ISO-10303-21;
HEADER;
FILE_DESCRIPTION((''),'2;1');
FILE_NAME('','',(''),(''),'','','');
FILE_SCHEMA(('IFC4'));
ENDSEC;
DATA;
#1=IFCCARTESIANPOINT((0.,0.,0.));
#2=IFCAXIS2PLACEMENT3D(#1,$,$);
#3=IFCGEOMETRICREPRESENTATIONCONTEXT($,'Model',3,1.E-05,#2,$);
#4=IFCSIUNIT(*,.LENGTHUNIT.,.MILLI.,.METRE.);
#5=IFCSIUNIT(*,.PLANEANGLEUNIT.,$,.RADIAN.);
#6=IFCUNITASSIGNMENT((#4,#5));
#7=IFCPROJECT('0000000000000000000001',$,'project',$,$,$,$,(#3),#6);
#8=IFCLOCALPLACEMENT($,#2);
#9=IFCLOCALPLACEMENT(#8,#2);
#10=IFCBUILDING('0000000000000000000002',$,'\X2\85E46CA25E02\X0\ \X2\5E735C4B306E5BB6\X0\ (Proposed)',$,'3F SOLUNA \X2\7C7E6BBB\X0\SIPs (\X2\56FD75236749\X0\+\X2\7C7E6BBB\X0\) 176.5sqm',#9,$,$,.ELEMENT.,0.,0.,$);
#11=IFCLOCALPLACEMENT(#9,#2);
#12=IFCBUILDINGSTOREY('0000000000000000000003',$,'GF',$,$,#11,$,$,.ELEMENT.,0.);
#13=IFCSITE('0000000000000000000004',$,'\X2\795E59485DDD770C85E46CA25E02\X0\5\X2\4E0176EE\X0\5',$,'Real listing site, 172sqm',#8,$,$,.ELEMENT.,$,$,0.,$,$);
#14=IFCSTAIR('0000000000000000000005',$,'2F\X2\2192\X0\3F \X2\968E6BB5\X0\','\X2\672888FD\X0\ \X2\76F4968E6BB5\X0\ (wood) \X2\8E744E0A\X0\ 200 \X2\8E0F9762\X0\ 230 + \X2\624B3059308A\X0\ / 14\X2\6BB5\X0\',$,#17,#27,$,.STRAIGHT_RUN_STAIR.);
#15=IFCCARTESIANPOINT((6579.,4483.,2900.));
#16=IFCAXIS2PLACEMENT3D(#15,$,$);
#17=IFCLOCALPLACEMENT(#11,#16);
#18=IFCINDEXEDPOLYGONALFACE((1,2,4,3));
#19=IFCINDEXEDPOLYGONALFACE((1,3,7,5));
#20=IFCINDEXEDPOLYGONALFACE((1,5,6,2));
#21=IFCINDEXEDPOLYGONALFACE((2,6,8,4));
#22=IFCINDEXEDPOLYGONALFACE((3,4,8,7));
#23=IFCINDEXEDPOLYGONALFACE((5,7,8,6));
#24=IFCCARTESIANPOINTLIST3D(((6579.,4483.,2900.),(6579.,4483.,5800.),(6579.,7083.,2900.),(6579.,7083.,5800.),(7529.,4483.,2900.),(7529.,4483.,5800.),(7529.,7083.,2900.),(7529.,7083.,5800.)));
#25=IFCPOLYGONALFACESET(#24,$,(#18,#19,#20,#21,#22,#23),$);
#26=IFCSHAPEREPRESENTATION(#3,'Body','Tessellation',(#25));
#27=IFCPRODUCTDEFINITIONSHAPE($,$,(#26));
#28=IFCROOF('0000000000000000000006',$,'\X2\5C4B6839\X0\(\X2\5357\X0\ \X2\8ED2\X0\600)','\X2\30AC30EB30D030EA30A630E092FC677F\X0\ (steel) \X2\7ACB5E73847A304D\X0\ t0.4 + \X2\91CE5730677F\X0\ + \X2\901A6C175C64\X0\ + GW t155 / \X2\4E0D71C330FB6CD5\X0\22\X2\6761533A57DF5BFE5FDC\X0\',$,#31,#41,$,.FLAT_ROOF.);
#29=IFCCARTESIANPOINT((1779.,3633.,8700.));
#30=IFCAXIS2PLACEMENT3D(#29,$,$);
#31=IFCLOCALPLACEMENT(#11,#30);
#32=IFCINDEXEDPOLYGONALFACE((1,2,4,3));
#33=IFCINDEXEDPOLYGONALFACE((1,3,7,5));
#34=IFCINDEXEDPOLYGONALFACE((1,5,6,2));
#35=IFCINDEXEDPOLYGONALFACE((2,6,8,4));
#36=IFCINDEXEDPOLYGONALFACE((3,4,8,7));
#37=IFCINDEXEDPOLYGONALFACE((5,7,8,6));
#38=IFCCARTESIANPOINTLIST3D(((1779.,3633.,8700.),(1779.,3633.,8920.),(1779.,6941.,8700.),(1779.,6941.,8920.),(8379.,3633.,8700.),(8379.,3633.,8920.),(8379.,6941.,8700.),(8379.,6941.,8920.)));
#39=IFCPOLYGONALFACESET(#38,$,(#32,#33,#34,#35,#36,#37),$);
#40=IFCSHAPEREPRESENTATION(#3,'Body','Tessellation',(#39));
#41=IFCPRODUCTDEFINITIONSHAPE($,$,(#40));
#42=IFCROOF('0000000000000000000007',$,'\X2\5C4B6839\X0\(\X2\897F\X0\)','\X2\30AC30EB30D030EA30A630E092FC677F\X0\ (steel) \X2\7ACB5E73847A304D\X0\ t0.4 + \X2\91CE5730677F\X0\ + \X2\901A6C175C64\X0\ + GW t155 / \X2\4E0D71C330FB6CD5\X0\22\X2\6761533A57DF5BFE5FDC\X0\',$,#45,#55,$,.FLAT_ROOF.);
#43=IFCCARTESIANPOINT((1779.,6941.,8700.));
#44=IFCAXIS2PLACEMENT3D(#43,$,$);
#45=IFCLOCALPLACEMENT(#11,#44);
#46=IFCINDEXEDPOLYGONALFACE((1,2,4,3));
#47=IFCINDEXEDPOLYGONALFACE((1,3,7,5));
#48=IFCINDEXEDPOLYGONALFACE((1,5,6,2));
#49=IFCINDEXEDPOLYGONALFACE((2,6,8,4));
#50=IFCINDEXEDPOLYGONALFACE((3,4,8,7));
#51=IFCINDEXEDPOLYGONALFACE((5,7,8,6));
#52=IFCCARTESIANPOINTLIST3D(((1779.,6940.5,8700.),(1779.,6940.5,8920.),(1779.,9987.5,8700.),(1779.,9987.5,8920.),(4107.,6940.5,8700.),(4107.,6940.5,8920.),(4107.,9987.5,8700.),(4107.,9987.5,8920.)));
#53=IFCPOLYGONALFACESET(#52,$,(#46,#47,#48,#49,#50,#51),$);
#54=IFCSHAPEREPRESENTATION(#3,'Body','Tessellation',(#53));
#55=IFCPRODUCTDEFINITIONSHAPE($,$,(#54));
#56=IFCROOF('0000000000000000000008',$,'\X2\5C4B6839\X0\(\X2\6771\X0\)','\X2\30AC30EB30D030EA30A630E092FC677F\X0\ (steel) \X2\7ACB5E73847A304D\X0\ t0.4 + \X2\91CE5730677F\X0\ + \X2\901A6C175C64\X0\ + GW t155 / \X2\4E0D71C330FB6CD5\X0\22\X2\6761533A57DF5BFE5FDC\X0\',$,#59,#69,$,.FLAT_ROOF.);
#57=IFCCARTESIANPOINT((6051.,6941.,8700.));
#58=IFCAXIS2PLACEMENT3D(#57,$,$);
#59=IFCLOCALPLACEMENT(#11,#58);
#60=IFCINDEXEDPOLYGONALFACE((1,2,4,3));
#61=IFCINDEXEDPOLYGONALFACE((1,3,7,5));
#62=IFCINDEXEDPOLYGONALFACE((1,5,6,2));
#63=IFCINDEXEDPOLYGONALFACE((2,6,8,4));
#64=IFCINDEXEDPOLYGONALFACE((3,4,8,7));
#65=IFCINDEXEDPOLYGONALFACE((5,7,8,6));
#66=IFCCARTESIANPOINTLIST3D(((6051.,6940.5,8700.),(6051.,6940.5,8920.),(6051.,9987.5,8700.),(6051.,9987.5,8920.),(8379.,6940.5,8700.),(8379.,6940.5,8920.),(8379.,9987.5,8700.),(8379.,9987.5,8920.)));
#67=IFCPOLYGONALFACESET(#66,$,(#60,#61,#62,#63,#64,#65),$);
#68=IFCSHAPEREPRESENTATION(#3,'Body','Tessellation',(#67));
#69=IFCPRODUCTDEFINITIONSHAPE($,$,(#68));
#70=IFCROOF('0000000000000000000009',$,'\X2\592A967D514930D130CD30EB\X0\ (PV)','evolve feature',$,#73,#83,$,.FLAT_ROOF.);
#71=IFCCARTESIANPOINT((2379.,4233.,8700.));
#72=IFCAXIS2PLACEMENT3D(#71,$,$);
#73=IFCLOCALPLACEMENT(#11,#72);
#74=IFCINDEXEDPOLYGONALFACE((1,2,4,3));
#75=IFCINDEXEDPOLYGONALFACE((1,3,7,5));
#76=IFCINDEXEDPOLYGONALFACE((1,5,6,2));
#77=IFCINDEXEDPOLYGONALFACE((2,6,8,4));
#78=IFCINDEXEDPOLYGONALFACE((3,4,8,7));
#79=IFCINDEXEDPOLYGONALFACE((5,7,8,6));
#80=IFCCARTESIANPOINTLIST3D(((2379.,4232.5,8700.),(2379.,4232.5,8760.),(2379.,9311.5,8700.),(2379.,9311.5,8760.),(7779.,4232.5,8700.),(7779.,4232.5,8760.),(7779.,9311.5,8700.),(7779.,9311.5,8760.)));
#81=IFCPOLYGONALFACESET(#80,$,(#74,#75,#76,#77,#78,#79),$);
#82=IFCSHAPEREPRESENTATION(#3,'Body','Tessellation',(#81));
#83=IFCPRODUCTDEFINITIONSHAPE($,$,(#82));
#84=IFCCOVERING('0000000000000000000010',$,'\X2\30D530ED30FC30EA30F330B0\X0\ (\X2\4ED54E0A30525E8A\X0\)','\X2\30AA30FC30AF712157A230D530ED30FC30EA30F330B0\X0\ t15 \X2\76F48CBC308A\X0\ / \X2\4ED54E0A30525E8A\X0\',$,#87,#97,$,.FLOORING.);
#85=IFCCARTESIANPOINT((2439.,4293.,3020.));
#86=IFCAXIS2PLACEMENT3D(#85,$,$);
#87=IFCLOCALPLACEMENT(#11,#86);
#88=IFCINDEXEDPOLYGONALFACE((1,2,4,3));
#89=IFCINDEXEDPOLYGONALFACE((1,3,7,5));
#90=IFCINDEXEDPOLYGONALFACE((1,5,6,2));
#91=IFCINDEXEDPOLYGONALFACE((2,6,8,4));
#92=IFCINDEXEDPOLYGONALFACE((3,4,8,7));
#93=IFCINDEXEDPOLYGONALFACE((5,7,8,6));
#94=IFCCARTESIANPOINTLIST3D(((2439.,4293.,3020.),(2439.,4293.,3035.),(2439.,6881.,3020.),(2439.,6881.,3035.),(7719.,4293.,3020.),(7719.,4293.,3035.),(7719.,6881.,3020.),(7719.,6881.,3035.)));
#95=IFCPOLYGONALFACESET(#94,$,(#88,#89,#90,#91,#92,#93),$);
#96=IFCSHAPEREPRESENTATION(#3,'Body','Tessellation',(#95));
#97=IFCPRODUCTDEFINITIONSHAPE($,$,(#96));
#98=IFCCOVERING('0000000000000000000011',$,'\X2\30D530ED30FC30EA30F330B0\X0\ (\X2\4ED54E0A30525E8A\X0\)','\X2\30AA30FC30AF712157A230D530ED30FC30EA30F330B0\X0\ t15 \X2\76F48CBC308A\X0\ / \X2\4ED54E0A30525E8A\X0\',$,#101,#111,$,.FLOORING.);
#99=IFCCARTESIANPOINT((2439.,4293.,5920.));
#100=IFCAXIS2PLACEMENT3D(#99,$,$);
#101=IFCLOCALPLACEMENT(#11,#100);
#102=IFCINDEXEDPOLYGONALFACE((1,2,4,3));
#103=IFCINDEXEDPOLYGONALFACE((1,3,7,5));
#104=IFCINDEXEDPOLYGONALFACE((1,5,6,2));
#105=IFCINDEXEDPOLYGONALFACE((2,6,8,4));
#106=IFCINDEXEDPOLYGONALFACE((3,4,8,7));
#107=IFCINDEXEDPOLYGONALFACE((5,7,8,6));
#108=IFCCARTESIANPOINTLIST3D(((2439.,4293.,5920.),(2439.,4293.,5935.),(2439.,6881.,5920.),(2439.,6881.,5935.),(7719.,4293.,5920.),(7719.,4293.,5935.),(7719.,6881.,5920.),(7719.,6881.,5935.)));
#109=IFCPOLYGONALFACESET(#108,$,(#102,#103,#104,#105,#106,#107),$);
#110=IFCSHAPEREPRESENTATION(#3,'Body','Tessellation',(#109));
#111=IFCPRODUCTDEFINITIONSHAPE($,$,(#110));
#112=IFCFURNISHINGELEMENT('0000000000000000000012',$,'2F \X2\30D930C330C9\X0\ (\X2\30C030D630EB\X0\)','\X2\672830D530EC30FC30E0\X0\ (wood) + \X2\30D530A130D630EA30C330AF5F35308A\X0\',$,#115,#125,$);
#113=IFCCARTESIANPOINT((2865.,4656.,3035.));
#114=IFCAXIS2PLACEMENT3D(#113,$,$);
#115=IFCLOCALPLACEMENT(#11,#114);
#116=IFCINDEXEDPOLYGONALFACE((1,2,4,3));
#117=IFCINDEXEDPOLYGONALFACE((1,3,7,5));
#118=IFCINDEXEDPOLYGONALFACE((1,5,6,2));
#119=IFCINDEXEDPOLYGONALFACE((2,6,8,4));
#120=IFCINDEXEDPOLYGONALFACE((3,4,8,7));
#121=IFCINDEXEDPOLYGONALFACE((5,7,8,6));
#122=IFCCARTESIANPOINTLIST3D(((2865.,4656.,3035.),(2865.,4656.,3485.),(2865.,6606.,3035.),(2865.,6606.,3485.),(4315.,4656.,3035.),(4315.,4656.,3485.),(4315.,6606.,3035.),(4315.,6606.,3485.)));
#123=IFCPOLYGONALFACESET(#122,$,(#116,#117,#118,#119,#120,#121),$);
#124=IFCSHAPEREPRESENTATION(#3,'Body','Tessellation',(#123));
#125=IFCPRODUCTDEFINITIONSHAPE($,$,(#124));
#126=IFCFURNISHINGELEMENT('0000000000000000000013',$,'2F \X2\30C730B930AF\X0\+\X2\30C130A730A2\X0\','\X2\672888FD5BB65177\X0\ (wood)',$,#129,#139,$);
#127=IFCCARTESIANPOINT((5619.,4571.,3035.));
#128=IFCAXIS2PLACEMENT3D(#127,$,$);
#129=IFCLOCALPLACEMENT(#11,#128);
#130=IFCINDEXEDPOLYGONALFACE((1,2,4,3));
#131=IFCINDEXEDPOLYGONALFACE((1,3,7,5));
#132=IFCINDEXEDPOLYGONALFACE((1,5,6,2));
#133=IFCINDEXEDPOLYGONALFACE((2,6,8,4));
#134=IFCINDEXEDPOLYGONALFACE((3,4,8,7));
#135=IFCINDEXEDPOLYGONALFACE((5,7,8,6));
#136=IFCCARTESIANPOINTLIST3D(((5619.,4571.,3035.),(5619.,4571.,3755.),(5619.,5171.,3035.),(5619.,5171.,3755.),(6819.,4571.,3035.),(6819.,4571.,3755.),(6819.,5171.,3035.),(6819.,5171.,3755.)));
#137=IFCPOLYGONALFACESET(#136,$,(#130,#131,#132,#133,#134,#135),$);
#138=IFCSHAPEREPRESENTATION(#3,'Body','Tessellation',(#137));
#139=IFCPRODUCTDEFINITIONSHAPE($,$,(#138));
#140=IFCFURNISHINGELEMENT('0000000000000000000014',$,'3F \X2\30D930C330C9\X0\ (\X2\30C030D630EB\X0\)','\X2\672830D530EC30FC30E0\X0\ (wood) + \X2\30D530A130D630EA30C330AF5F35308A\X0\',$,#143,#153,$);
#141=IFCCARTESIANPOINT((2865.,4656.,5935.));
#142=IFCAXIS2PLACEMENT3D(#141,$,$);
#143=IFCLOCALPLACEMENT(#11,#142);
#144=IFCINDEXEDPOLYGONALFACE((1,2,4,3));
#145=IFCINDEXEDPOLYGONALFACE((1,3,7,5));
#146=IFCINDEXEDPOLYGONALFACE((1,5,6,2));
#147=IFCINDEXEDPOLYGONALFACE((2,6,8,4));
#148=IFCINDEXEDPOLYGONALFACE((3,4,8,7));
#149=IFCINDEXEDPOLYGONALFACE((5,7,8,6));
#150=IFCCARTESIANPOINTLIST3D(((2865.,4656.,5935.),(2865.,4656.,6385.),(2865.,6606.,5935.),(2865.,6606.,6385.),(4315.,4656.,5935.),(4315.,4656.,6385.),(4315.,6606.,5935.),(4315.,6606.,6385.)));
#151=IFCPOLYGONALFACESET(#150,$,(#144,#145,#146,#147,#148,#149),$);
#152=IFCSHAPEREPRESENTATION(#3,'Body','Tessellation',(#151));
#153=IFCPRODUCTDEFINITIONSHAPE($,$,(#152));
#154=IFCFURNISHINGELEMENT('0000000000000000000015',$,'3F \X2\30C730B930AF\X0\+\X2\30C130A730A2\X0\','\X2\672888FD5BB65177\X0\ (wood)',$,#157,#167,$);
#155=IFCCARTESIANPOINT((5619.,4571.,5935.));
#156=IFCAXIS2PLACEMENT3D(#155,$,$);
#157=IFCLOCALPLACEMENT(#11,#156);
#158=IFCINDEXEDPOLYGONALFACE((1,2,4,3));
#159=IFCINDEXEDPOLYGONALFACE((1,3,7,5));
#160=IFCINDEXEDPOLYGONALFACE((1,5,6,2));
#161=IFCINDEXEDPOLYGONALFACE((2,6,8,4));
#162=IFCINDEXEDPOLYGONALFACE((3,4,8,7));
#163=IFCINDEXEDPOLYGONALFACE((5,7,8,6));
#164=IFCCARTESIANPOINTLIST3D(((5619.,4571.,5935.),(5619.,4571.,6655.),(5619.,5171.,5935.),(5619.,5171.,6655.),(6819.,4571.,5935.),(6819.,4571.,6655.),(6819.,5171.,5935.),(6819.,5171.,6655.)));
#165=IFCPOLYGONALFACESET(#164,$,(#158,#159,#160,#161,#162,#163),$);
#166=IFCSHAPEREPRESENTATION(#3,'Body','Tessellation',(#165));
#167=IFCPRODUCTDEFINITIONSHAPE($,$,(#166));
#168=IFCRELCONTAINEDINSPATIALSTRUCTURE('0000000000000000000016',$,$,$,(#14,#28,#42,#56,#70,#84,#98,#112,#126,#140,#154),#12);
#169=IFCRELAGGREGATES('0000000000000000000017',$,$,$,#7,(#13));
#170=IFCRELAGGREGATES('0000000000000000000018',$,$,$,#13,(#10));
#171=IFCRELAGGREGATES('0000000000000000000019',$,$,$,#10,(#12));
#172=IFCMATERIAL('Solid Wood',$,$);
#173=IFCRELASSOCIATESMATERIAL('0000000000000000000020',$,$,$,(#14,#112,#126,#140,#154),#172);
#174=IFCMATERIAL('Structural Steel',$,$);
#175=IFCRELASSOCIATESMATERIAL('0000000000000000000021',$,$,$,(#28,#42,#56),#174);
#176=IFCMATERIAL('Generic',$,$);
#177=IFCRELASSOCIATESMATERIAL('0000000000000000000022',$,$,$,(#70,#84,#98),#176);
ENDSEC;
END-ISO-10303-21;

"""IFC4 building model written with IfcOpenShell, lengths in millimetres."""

from ifc_helpers import new_model, si_unit, frame, frame_2d, origin, place, context, project, spatial, rectangle, extrude, material, element, save


model = new_model("IFC4")

# Units and contexts
model_context = context("Model", 3, precision=1e-05, world=origin())
ifc_project = project(units=[si_unit("LENGTHUNIT", "METRE", prefix="MILLI"), si_unit("PLANEANGLEUNIT", "RADIAN")], contexts=[model_context])

# Site, building, storey
site_placement = place(None, origin())
site = spatial("IfcSite", under=ifc_project, at=site_placement, Name="神奈川県藤沢市5丁目5", ObjectType="Real listing site, 172sqm", CompositionType="ELEMENT", RefElevation=0.0)
building_placement = place(site_placement, origin())
building = spatial("IfcBuilding", under=site, at=building_placement, Name="藤沢市 平屋の家 (Proposed)", ObjectType="3F SOLUNA 籾殻SIPs (国産杉+籾殻) 176.5sqm", CompositionType="ELEMENT", ElevationOfRefHeight=0.0, ElevationOfTerrain=0.0)
storey_placement = place(building_placement, origin())
storey = spatial("IfcBuildingStorey", under=building, at=storey_placement, Name="GF", CompositionType="ELEMENT", Elevation=0.0)

# Shared definitions
ifc_material_1 = material(Name="Solid Wood")

# Stair
stair_placement = place(storey_placement, frame((6579.0, 4483.0, 2900.0)))
element("IfcStair", 1, at=stair_placement, inside=storey, material=ifc_material_1, Name="2F→3F 階段", Description="木製 直階段 (wood) 蹴上 200 踏面 230 + 手すり / 14段", PredefinedType="STRAIGHT_RUN_STAIR", context=model_context, shape_type="SweptSolid", body=[
    extrude(rectangle(XDim=950.0, YDim=2600.0, at=frame_2d((475.0, 1300.0))), frame((6579.0, 4483.0, 2900.0)), (0.0, 0.0, 1.0), 2900.0),
])

# Roofs
ifc_material_2 = material(Name="Structural Steel")
roof_1_placement = place(storey_placement, frame((1779.0, 3633.0, 8700.0)))
element("IfcRoof", 2, at=roof_1_placement, inside=storey, material=ifc_material_2, Name="屋根(南 軒600)", Description="ガルバリウム鋼板 (steel) 立平葺き t0.4 + 野地板 + 通気層 + GW t155 / 不燃・法22条区域対応", PredefinedType="FLAT_ROOF", context=model_context, shape_type="SweptSolid", body=[
    extrude(rectangle(XDim=6600.0, YDim=3308.0, at=frame_2d((3300.0, 1654.0))), frame((1779.0, 3633.0, 8700.0)), (0.0, 0.0, 1.0), 220.0),
])
roof_2_placement = place(storey_placement, frame((1779.0, 6941.0, 8700.0)))
element("IfcRoof", 3, at=roof_2_placement, inside=storey, material=ifc_material_2, Name="屋根(西)", Description="ガルバリウム鋼板 (steel) 立平葺き t0.4 + 野地板 + 通気層 + GW t155 / 不燃・法22条区域対応", PredefinedType="FLAT_ROOF", context=model_context, shape_type="SweptSolid", body=[
    extrude(rectangle(XDim=2328.0, YDim=3047.0, at=frame_2d((1164.0, 1523.0))), frame((1779.0, 6941.0, 8700.0)), (0.0, 0.0, 1.0), 220.0),
])
roof_3_placement = place(storey_placement, frame((6051.0, 6941.0, 8700.0)))
element("IfcRoof", 4, at=roof_3_placement, inside=storey, material=ifc_material_2, Name="屋根(東)", Description="ガルバリウム鋼板 (steel) 立平葺き t0.4 + 野地板 + 通気層 + GW t155 / 不燃・法22条区域対応", PredefinedType="FLAT_ROOF", context=model_context, shape_type="SweptSolid", body=[
    extrude(rectangle(XDim=2328.0, YDim=3047.0, at=frame_2d((1164.0, 1523.0))), frame((6051.0, 6941.0, 8700.0)), (0.0, 0.0, 1.0), 220.0),
])
ifc_material_3 = material(Name="Generic")
roof_4_placement = place(storey_placement, frame((2379.0, 4233.0, 8700.0)))
element("IfcRoof", 5, at=roof_4_placement, inside=storey, material=ifc_material_3, Name="太陽光パネル (PV)", Description="evolve feature", PredefinedType="FLAT_ROOF", context=model_context, shape_type="SweptSolid", body=[
    extrude(rectangle(XDim=5400.0, YDim=5079.0, at=frame_2d((2700.0, 2539.0))), frame((2379.0, 4233.0, 8700.0)), (0.0, 0.0, 1.0), 60.0),
])

# Coverings
covering_1_placement = place(storey_placement, frame((2439.0, 4293.0, 3020.0)))
element("IfcCovering", 6, at=covering_1_placement, inside=storey, material=ifc_material_3, Name="フローリング (仕上げ床)", Description="オーク無垢フローリング t15 直貼り / 仕上げ床", PredefinedType="FLOORING", context=model_context, shape_type="SweptSolid", body=[
    extrude(rectangle(XDim=5280.0, YDim=2588.0, at=frame_2d((2640.0, 1294.0))), frame((2439.0, 4293.0, 3020.0)), (0.0, 0.0, 1.0), 15.0),
])
covering_2_placement = place(storey_placement, frame((2439.0, 4293.0, 5920.0)))
element("IfcCovering", 7, at=covering_2_placement, inside=storey, material=ifc_material_3, Name="フローリング (仕上げ床)", Description="オーク無垢フローリング t15 直貼り / 仕上げ床", PredefinedType="FLOORING", context=model_context, shape_type="SweptSolid", body=[
    extrude(rectangle(XDim=5280.0, YDim=2588.0, at=frame_2d((2640.0, 1294.0))), frame((2439.0, 4293.0, 5920.0)), (0.0, 0.0, 1.0), 15.0),
])

# Furnishing elements
furnishing_1_placement = place(storey_placement, frame((2865.0, 4656.0, 3035.0)))
element("IfcFurnishingElement", 8, at=furnishing_1_placement, inside=storey, material=ifc_material_1, Name="2F ベッド (ダブル)", Description="木フレーム (wood) + ファブリック張り", context=model_context, shape_type="SweptSolid", body=[
    extrude(rectangle(XDim=1450.0, YDim=1950.0, at=frame_2d((725.0, 975.0))), frame((2865.0, 4656.0, 3035.0)), (0.0, 0.0, 1.0), 450.0),
])
furnishing_2_placement = place(storey_placement, frame((5619.0, 4571.0, 3035.0)))
element("IfcFurnishingElement", 9, at=furnishing_2_placement, inside=storey, material=ifc_material_1, Name="2F デスク+チェア", Description="木製家具 (wood)", context=model_context, shape_type="SweptSolid", body=[
    extrude(rectangle(XDim=1200.0, YDim=600.0, at=frame_2d((600.0, 300.0))), frame((5619.0, 4571.0, 3035.0)), (0.0, 0.0, 1.0), 720.0),
])
furnishing_3_placement = place(storey_placement, frame((2865.0, 4656.0, 5935.0)))
element("IfcFurnishingElement", 10, at=furnishing_3_placement, inside=storey, material=ifc_material_1, Name="3F ベッド (ダブル)", Description="木フレーム (wood) + ファブリック張り", context=model_context, shape_type="SweptSolid", body=[
    extrude(rectangle(XDim=1450.0, YDim=1950.0, at=frame_2d((725.0, 975.0))), frame((2865.0, 4656.0, 5935.0)), (0.0, 0.0, 1.0), 450.0),
])
furnishing_4_placement = place(storey_placement, frame((5619.0, 4571.0, 5935.0)))
element("IfcFurnishingElement", 11, at=furnishing_4_placement, inside=storey, material=ifc_material_1, Name="3F デスク+チェア", Description="木製家具 (wood)", context=model_context, shape_type="SweptSolid", body=[
    extrude(rectangle(XDim=1200.0, YDim=600.0, at=frame_2d((600.0, 300.0))), frame((5619.0, 4571.0, 5935.0)), (0.0, 0.0, 1.0), 720.0),
])

save(model, "model.ifc")
